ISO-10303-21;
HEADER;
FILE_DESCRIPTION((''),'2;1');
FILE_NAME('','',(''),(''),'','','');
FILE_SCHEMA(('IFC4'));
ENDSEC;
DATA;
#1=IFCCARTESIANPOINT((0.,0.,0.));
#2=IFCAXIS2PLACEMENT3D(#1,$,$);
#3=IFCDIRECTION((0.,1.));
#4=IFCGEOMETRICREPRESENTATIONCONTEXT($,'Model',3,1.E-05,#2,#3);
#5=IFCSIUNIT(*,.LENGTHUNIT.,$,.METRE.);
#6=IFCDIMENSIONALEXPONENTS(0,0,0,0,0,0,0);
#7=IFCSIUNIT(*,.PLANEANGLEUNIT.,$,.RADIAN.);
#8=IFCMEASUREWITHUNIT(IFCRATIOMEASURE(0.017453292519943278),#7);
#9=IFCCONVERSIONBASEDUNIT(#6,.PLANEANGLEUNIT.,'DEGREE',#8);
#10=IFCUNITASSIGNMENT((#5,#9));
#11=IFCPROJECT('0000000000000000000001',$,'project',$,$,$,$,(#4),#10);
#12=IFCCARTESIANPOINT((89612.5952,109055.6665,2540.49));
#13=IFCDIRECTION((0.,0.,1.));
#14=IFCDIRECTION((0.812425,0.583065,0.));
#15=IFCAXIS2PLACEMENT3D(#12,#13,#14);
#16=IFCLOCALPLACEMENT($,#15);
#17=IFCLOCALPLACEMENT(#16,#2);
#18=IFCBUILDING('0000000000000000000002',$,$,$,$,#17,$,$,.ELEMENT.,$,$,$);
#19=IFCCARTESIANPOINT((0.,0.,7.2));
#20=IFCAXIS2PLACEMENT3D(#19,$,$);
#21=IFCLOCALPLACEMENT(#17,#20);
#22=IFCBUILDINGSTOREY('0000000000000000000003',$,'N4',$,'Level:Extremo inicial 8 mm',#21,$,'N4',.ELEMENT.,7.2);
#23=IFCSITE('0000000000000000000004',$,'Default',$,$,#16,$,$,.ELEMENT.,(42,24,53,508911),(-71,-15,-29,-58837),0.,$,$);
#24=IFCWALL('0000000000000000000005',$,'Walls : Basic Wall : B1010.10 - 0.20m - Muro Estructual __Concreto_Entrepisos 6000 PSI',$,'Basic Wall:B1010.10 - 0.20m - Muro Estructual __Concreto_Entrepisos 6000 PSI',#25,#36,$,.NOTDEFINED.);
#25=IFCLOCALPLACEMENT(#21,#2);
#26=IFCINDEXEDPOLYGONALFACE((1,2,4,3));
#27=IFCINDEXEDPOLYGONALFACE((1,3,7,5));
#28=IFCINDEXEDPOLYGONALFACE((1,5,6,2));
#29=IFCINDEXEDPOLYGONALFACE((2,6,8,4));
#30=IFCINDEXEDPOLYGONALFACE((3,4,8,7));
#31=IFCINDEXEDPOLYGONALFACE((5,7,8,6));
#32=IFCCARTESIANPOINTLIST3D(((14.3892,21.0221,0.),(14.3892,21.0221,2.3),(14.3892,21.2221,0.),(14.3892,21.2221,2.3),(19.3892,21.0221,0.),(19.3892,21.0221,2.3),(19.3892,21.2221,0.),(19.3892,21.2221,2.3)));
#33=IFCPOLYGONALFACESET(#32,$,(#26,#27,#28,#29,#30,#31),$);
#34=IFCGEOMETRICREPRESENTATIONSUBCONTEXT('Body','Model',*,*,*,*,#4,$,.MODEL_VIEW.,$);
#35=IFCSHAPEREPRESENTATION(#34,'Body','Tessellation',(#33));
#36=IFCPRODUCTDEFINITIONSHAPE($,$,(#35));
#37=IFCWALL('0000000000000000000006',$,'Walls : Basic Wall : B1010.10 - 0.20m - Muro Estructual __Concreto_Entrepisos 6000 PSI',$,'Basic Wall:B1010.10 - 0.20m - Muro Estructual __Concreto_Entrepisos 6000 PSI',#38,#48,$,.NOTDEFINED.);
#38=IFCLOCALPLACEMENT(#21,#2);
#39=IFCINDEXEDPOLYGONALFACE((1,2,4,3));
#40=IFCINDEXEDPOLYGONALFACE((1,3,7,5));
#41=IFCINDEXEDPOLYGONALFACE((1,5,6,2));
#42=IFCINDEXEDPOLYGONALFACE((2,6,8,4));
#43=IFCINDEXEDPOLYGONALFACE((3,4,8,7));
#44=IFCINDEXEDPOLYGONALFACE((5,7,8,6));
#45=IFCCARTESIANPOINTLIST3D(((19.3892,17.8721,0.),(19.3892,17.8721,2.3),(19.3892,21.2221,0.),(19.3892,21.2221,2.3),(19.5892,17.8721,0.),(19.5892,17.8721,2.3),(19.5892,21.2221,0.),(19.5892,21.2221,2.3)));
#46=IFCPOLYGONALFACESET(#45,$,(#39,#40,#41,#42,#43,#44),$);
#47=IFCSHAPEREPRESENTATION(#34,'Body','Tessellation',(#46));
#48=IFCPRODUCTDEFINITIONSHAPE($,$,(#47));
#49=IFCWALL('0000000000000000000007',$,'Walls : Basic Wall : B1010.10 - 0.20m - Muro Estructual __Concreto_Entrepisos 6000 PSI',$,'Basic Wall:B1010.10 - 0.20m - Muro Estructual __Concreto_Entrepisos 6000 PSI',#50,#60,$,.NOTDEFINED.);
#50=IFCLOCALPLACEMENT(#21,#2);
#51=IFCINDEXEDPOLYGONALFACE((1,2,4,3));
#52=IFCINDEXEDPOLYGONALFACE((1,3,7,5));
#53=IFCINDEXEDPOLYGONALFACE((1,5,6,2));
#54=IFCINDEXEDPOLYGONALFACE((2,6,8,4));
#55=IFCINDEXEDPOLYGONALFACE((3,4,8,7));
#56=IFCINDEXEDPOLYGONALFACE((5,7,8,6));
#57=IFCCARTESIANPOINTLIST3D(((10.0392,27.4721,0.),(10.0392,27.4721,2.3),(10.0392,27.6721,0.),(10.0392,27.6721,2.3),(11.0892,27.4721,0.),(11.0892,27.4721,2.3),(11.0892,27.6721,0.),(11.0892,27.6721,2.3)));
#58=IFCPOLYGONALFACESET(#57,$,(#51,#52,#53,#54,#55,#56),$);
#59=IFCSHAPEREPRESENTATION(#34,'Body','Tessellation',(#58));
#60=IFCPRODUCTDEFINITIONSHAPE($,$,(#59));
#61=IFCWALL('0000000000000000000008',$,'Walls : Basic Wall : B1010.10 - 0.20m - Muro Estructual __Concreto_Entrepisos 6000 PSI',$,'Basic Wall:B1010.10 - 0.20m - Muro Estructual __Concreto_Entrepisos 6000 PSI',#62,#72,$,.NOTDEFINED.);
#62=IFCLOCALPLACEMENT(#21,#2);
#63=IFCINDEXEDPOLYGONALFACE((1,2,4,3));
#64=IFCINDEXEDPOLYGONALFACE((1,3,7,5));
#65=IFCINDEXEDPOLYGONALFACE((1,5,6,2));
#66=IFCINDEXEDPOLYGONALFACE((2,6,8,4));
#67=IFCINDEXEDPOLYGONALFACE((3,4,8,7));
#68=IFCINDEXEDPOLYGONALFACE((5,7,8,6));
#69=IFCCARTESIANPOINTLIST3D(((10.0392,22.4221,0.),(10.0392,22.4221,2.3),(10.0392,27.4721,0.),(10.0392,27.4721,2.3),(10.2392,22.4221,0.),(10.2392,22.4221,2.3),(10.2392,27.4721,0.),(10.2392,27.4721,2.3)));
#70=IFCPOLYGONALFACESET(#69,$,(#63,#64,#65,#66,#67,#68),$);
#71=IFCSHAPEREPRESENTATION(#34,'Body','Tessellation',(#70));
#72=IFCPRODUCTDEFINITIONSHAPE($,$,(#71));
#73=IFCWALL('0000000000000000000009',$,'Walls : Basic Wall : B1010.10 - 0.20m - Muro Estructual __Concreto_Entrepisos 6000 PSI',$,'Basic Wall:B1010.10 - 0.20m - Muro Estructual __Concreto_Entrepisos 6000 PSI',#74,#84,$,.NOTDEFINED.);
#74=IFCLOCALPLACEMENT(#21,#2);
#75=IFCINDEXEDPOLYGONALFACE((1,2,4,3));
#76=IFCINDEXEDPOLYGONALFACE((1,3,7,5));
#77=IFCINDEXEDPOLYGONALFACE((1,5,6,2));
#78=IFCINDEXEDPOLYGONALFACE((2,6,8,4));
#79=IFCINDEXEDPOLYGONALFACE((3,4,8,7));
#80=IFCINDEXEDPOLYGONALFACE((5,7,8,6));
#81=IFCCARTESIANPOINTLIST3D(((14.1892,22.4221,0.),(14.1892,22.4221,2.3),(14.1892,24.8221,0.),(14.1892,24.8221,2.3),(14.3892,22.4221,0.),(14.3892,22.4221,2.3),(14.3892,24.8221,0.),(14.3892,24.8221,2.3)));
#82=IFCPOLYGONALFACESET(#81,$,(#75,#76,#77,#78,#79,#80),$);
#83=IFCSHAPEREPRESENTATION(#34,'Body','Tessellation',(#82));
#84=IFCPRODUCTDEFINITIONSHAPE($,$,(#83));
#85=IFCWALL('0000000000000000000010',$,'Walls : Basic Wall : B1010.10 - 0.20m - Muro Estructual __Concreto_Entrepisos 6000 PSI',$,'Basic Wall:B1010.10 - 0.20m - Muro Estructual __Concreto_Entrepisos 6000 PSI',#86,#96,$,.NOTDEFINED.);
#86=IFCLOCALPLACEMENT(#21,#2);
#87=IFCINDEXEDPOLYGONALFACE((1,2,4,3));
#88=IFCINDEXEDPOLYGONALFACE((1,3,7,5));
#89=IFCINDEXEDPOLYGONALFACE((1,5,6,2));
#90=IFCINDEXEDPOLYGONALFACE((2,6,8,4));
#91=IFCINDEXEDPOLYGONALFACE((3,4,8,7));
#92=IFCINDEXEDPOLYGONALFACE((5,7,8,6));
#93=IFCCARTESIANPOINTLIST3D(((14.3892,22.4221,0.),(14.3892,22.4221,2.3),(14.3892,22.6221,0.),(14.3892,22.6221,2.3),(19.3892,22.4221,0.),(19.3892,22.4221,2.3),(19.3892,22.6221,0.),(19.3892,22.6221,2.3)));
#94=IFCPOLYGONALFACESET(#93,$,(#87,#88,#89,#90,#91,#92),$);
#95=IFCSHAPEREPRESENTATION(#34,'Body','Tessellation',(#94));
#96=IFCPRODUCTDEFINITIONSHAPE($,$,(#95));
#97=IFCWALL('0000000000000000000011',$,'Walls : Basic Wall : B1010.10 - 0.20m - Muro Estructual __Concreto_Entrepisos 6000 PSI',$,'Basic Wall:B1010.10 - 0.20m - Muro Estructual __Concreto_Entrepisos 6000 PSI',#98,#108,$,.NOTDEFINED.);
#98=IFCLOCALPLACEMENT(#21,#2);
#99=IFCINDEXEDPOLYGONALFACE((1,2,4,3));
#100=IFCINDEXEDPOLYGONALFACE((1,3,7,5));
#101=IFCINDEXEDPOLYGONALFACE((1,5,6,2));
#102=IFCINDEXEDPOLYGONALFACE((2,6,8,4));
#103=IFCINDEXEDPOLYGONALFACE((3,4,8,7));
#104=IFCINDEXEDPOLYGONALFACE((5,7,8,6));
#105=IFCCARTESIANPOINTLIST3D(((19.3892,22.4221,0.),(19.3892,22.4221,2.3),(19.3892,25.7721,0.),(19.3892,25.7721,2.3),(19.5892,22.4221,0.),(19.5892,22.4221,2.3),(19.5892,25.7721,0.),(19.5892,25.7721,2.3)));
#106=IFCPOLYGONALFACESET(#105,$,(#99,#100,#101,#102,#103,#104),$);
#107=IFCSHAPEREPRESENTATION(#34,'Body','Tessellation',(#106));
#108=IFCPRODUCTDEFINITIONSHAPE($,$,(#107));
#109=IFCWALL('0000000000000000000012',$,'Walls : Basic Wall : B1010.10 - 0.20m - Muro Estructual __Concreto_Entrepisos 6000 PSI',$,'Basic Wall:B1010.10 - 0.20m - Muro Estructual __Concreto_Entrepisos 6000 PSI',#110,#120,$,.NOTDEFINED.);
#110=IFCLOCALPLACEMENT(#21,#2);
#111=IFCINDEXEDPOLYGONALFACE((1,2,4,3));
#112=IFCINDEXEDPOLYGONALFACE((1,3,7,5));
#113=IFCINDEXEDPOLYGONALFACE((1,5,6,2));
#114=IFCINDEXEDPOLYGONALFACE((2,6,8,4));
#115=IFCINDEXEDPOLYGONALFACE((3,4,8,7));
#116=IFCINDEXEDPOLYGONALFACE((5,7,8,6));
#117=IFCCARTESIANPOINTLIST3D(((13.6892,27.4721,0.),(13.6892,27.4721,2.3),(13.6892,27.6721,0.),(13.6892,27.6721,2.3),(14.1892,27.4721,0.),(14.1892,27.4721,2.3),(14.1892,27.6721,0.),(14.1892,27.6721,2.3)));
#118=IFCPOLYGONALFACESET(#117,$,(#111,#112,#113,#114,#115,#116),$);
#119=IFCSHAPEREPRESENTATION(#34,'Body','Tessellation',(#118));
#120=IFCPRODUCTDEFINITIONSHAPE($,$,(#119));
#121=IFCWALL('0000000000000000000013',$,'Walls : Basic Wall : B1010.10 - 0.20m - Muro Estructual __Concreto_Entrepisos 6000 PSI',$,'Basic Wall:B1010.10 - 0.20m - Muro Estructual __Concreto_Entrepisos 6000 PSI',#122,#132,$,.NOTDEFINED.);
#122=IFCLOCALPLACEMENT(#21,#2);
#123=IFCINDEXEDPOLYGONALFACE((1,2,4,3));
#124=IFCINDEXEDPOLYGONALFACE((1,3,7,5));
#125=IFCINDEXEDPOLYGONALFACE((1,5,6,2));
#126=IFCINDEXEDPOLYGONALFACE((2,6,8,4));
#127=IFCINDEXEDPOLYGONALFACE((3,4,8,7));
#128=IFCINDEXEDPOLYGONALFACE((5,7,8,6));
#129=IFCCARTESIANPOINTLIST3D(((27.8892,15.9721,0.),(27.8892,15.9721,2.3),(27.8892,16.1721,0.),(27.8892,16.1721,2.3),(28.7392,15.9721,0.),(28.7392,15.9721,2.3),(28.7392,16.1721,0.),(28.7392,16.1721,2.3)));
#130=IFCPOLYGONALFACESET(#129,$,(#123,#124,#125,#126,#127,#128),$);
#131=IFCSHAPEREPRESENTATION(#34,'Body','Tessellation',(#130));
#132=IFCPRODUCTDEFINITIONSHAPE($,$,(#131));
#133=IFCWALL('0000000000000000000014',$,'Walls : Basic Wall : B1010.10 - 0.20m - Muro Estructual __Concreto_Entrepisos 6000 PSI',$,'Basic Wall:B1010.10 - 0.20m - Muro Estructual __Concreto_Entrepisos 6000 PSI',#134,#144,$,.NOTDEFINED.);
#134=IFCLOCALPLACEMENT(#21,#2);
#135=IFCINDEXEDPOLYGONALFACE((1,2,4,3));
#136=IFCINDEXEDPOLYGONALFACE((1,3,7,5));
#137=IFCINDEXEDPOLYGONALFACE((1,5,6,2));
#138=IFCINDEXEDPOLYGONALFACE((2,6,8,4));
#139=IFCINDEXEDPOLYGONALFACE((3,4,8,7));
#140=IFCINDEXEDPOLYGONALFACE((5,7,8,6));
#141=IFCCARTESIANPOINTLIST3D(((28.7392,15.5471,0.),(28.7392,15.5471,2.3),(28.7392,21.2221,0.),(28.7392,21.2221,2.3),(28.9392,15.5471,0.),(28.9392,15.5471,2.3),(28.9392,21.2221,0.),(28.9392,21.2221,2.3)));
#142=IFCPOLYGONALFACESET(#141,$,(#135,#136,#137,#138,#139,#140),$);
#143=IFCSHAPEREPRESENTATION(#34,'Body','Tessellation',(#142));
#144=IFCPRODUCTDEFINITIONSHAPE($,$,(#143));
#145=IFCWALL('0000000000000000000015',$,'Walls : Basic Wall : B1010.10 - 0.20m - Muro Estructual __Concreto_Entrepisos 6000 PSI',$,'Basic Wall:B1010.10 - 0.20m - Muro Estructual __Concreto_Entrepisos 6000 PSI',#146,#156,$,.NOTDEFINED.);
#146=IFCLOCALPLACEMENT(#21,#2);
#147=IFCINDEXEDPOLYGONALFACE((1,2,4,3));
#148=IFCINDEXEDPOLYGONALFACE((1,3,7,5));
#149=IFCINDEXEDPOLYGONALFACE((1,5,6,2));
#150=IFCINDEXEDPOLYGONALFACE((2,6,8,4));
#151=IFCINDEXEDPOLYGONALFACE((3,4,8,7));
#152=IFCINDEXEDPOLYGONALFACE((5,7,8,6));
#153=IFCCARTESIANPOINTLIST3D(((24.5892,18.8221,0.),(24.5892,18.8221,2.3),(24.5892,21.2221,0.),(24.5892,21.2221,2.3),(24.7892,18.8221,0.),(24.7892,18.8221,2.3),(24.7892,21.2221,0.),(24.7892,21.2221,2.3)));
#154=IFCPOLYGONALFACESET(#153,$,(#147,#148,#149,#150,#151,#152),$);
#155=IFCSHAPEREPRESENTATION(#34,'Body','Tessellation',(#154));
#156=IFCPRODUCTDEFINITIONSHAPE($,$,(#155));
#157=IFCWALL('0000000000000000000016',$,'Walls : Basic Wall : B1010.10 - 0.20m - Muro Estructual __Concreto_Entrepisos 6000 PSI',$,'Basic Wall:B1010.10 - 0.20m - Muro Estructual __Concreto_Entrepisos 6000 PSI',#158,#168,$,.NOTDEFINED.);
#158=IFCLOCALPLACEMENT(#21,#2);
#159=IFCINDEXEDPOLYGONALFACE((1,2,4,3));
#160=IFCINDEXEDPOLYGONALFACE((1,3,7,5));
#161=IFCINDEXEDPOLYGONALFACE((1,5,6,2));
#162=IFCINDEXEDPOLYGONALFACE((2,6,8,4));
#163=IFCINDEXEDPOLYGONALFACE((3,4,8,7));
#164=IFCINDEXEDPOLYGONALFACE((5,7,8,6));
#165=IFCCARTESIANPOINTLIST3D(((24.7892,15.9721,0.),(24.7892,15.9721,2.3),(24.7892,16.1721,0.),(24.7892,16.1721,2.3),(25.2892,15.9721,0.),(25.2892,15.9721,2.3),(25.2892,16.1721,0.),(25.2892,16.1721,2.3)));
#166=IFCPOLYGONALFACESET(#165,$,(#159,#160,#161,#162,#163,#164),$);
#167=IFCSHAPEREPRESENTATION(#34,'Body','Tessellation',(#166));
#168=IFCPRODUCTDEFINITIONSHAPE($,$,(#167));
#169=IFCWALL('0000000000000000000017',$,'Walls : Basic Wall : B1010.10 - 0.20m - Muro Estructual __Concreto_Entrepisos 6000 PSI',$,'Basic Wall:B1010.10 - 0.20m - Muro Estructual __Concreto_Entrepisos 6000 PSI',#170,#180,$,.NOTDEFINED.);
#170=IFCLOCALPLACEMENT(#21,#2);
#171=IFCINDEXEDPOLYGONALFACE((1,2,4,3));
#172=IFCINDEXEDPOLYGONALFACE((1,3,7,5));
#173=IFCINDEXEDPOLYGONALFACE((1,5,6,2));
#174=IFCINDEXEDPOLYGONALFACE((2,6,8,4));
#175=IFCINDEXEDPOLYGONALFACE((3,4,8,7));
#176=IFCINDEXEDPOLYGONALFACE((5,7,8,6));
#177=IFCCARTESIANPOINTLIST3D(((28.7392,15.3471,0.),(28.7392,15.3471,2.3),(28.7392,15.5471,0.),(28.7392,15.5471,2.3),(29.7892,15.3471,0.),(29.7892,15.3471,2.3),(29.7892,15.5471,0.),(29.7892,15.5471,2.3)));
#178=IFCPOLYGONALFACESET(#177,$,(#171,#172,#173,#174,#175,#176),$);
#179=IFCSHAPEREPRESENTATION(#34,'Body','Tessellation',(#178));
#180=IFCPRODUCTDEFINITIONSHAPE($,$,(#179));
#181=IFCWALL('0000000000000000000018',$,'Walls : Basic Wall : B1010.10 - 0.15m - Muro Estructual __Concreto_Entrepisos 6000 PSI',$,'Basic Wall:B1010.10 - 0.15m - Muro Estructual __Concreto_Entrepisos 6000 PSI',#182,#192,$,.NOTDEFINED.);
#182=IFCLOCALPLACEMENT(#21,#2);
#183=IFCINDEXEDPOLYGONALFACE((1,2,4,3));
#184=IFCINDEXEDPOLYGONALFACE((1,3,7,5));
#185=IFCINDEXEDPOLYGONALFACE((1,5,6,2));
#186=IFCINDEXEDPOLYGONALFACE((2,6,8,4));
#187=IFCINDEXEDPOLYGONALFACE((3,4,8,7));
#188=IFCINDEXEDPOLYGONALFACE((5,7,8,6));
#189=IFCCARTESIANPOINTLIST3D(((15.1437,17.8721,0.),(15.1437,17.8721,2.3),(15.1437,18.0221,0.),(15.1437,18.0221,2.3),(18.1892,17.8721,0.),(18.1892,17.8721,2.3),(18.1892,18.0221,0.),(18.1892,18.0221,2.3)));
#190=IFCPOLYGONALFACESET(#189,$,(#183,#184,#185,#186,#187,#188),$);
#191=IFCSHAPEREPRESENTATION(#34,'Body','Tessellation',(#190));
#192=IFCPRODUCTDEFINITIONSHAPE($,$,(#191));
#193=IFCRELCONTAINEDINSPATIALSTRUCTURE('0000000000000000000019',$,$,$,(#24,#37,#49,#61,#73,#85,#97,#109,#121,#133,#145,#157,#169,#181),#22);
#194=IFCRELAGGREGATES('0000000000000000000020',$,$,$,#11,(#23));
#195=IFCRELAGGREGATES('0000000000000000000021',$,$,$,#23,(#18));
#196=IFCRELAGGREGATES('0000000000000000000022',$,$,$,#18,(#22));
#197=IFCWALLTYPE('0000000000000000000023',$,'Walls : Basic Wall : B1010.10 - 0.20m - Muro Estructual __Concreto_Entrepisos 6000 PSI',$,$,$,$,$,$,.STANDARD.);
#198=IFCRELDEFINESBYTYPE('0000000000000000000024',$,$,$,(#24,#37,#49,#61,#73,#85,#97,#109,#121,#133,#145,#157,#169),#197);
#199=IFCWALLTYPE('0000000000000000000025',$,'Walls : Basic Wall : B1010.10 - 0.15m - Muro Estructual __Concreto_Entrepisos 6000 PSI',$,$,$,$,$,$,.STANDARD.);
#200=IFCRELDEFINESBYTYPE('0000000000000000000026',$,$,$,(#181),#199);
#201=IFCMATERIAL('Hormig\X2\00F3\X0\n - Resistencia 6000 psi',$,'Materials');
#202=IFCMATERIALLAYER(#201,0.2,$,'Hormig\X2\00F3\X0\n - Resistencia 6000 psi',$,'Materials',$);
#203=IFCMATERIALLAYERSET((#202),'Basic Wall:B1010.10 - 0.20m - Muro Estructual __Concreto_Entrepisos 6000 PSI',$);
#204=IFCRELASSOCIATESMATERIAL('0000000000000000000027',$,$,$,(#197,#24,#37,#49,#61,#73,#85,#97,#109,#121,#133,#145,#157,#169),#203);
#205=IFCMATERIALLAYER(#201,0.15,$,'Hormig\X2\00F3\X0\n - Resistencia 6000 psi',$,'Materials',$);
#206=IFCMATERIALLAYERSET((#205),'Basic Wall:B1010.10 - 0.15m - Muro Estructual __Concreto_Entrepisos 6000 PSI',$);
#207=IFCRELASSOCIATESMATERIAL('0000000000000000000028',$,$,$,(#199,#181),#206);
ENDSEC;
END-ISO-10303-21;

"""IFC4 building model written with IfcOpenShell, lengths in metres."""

from ifc_helpers import new_model, entity, si_unit, converted_unit, direction, frame, frame_2d, origin, place, context, subcontext, project, spatial, rectangle, extrude, material, layer, layer_set, layer_usage, type_object, element, save


model = new_model("IFC4")

# Units and contexts
model_context = context("Model", 3, precision=1e-05, world=origin(), true_north=direction((0.0, 1.0)))
body_context = subcontext(model_context, "Body", "Model", "MODEL_VIEW")
ifc_project = project(units=[si_unit("LENGTHUNIT", "METRE"), converted_unit("PLANEANGLEUNIT", "DEGREE", entity("IfcRatioMeasure", 0.017453292519943278), si_unit("PLANEANGLEUNIT", "RADIAN"), dimensions=[0, 0, 0, 0, 0, 0, 0])], contexts=[model_context])

# Site, building, storey
site_placement = place(None, frame((89612.5952, 109055.6665, 2540.49), z_axis=(0.0, 0.0, 1.0), x_axis=(0.812425, 0.583065, 0.0)))
site = spatial("IfcSite", under=ifc_project, at=site_placement, Name="Default", CompositionType="ELEMENT", RefLatitude=(42, 24, 53, 508911), RefLongitude=(-71, -15, -29, -58837), RefElevation=0.0)
building_placement = place(site_placement, origin())
building = spatial("IfcBuilding", under=site, at=building_placement, CompositionType="ELEMENT")
storey_placement = place(building_placement, frame((0.0, 0.0, 7.2)))
storey = spatial("IfcBuildingStorey", under=building, at=storey_placement, Name="N4", ObjectType="Level:Extremo inicial 8 mm", LongName="N4", CompositionType="ELEMENT", Elevation=7.2)

# Walls
ifc_material = material(Name="Hormigón - Resistencia 6000 psi", Category="Materials")
ifc_layer_1 = layer(ifc_material, 0.2, Name="Hormigón - Resistencia 6000 psi", Category="Materials")
ifc_layer_set_1 = layer_set([ifc_layer_1], Name="Basic Wall:B1010.10 - 0.20m - Muro Estructual __Concreto_Entrepisos 6000 PSI")
ifc_layer_usage_1 = layer_usage(ifc_layer_set_1, "AXIS2", "NEGATIVE", 0.1)
wall_type_1 = type_object("IfcWallType", Name="Walls : Basic Wall : B1010.10 - 0.20m - Muro Estructual __Concreto_Entrepisos 6000 PSI", PredefinedType="STANDARD", material=ifc_layer_set_1)
wall_1_placement = place(storey_placement, frame((14.3892, 21.1221, 0.0)))
element("IfcWall", 1, at=wall_1_placement, inside=storey, type_object=wall_type_1, material=ifc_layer_usage_1, Name="Walls : Basic Wall : B1010.10 - 0.20m - Muro Estructual __Concreto_Entrepisos 6000 PSI", ObjectType="Basic Wall:B1010.10 - 0.20m - Muro Estructual __Concreto_Entrepisos 6000 PSI", PredefinedType="NOTDEFINED", context=body_context, shape_type="SweptSolid", body=[
    extrude(rectangle(XDim=5.0, YDim=0.2, at=frame_2d((2.5, 0.0), x_axis=(-1.0, 0.0))), origin(), (0.0, 0.0, 1.0), 2.3),
])
ifc_layer_usage_2 = layer_usage(ifc_layer_set_1, "AXIS2", "NEGATIVE", 0.1)
wall_2_placement = place(storey_placement, frame((19.4892, 21.2221, 0.0), z_axis=(0.0, 0.0, 1.0), x_axis=(0.0, -1.0, 0.0)))
element("IfcWall", 2, at=wall_2_placement, inside=storey, type_object=wall_type_1, material=ifc_layer_usage_2, Name="Walls : Basic Wall : B1010.10 - 0.20m - Muro Estructual __Concreto_Entrepisos 6000 PSI", ObjectType="Basic Wall:B1010.10 - 0.20m - Muro Estructual __Concreto_Entrepisos 6000 PSI", PredefinedType="NOTDEFINED", context=body_context, shape_type="SweptSolid", body=[
    extrude(rectangle(XDim=3.35, YDim=0.2, at=frame_2d((1.675, 0.0), x_axis=(-1.0, 0.0))), origin(), (0.0, 0.0, 1.0), 2.3),
])
ifc_layer_usage_3 = layer_usage(ifc_layer_set_1, "AXIS2", "POSITIVE", -0.1)
wall_3_placement = place(storey_placement, frame((11.0892, 27.5721, 0.0), z_axis=(0.0, 0.0, 1.0), x_axis=(-1.0, 0.0, 0.0)))
element("IfcWall", 3, at=wall_3_placement, inside=storey, type_object=wall_type_1, material=ifc_layer_usage_3, Name="Walls : Basic Wall : B1010.10 - 0.20m - Muro Estructual __Concreto_Entrepisos 6000 PSI", ObjectType="Basic Wall:B1010.10 - 0.20m - Muro Estructual __Concreto_Entrepisos 6000 PSI", PredefinedType="NOTDEFINED", context=body_context, shape_type="SweptSolid", body=[
    extrude(rectangle(XDim=1.05, YDim=0.2, at=frame_2d((0.525, 0.0), x_axis=(-1.0, 0.0))), origin(), (0.0, 0.0, 1.0), 2.3),
])
ifc_layer_usage_4 = layer_usage(ifc_layer_set_1, "AXIS2", "POSITIVE", -0.1)
wall_4_placement = place(storey_placement, frame((10.1392, 27.4721, 0.0), z_axis=(0.0, 0.0, 1.0), x_axis=(0.0, -1.0, 0.0)))
element("IfcWall", 4, at=wall_4_placement, inside=storey, type_object=wall_type_1, material=ifc_layer_usage_4, Name="Walls : Basic Wall : B1010.10 - 0.20m - Muro Estructual __Concreto_Entrepisos 6000 PSI", ObjectType="Basic Wall:B1010.10 - 0.20m - Muro Estructual __Concreto_Entrepisos 6000 PSI", PredefinedType="NOTDEFINED", context=body_context, shape_type="SweptSolid", body=[
    extrude(rectangle(XDim=5.05, YDim=0.2, at=frame_2d((2.525, 0.0), x_axis=(-1.0, 0.0))), origin(), (0.0, 0.0, 1.0), 2.3),
])
ifc_layer_usage_5 = layer_usage(ifc_layer_set_1, "AXIS2", "POSITIVE", -0.1)
wall_5_placement = place(storey_placement, frame((14.2892, 24.8221, 0.0), z_axis=(0.0, 0.0, 1.0), x_axis=(0.0, -1.0, 0.0)))
element("IfcWall", 5, at=wall_5_placement, inside=storey, type_object=wall_type_1, material=ifc_layer_usage_5, Name="Walls : Basic Wall : B1010.10 - 0.20m - Muro Estructual __Concreto_Entrepisos 6000 PSI", ObjectType="Basic Wall:B1010.10 - 0.20m - Muro Estructual __Concreto_Entrepisos 6000 PSI", PredefinedType="NOTDEFINED", context=body_context, shape_type="SweptSolid", body=[
    extrude(rectangle(XDim=2.4, YDim=0.2, at=frame_2d((1.2, 0.0), x_axis=(-1.0, 0.0))), origin(), (0.0, 0.0, 1.0), 2.3),
])
ifc_layer_usage_6 = layer_usage(ifc_layer_set_1, "AXIS2", "POSITIVE", -0.1)
wall_6_placement = place(storey_placement, frame((14.3892, 22.5221, 0.0)))
element("IfcWall", 6, at=wall_6_placement, inside=storey, type_object=wall_type_1, material=ifc_layer_usage_6, Name="Walls : Basic Wall : B1010.10 - 0.20m - Muro Estructual __Concreto_Entrepisos 6000 PSI", ObjectType="Basic Wall:B1010.10 - 0.20m - Muro Estructual __Concreto_Entrepisos 6000 PSI", PredefinedType="NOTDEFINED", context=body_context, shape_type="SweptSolid", body=[
    extrude(rectangle(XDim=5.0, YDim=0.2, at=frame_2d((2.5, 0.0), x_axis=(-1.0, 0.0))), origin(), (0.0, 0.0, 1.0), 2.3),
])
ifc_layer_usage_7 = layer_usage(ifc_layer_set_1, "AXIS2", "POSITIVE", -0.1)
wall_7_placement = place(storey_placement, frame((19.4892, 22.4221, 0.0), z_axis=(0.0, 0.0, 1.0), x_axis=(0.0, 1.0, 0.0)))
element("IfcWall", 7, at=wall_7_placement, inside=storey, type_object=wall_type_1, material=ifc_layer_usage_7, Name="Walls : Basic Wall : B1010.10 - 0.20m - Muro Estructual __Concreto_Entrepisos 6000 PSI", ObjectType="Basic Wall:B1010.10 - 0.20m - Muro Estructual __Concreto_Entrepisos 6000 PSI", PredefinedType="NOTDEFINED", context=body_context, shape_type="SweptSolid", body=[
    extrude(rectangle(XDim=3.35, YDim=0.2, at=frame_2d((1.675, 0.0), x_axis=(-1.0, 0.0))), origin(), (0.0, 0.0, 1.0), 2.3),
])
ifc_layer_usage_8 = layer_usage(ifc_layer_set_1, "AXIS2", "POSITIVE", -0.1)
wall_8_placement = place(storey_placement, frame((13.6892, 27.5721, 0.0)))
element("IfcWall", 8, at=wall_8_placement, inside=storey, type_object=wall_type_1, material=ifc_layer_usage_8, Name="Walls : Basic Wall : B1010.10 - 0.20m - Muro Estructual __Concreto_Entrepisos 6000 PSI", ObjectType="Basic Wall:B1010.10 - 0.20m - Muro Estructual __Concreto_Entrepisos 6000 PSI", PredefinedType="NOTDEFINED", context=body_context, shape_type="SweptSolid", body=[
    extrude(rectangle(XDim=0.5, YDim=0.2, at=frame_2d((0.25, 0.0), x_axis=(-1.0, 0.0))), origin(), (0.0, 0.0, 1.0), 2.3),
])
ifc_layer_usage_9 = layer_usage(ifc_layer_set_1, "AXIS2", "POSITIVE", -0.1)
wall_9_placement = place(storey_placement, frame((27.8892, 16.0721, 0.0)))
element("IfcWall", 9, at=wall_9_placement, inside=storey, type_object=wall_type_1, material=ifc_layer_usage_9, Name="Walls : Basic Wall : B1010.10 - 0.20m - Muro Estructual __Concreto_Entrepisos 6000 PSI", ObjectType="Basic Wall:B1010.10 - 0.20m - Muro Estructual __Concreto_Entrepisos 6000 PSI", PredefinedType="NOTDEFINED", context=body_context, shape_type="SweptSolid", body=[
    extrude(rectangle(XDim=0.85, YDim=0.2, at=frame_2d((0.425, 0.0), x_axis=(-1.0, 0.0))), origin(), (0.0, 0.0, 1.0), 2.3),
])
ifc_layer_usage_10 = layer_usage(ifc_layer_set_1, "AXIS2", "POSITIVE", -0.1)
wall_10_placement = place(storey_placement, frame((28.8392, 15.5471, 0.0), z_axis=(0.0, 0.0, 1.0), x_axis=(0.0, 1.0, 0.0)))
element("IfcWall", 10, at=wall_10_placement, inside=storey, type_object=wall_type_1, material=ifc_layer_usage_10, Name="Walls : Basic Wall : B1010.10 - 0.20m - Muro Estructual __Concreto_Entrepisos 6000 PSI", ObjectType="Basic Wall:B1010.10 - 0.20m - Muro Estructual __Concreto_Entrepisos 6000 PSI", PredefinedType="NOTDEFINED", context=body_context, shape_type="SweptSolid", body=[
    extrude(rectangle(XDim=5.675, YDim=0.2, at=frame_2d((2.8375, 0.0), x_axis=(-1.0, 0.0))), origin(), (0.0, 0.0, 1.0), 2.3),
])
ifc_layer_usage_11 = layer_usage(ifc_layer_set_1, "AXIS2", "POSITIVE", -0.1)
wall_11_placement = place(storey_placement, frame((24.6892, 18.8221, 0.0), z_axis=(0.0, 0.0, 1.0), x_axis=(0.0, 1.0, 0.0)))
element("IfcWall", 11, at=wall_11_placement, inside=storey, type_object=wall_type_1, material=ifc_layer_usage_11, Name="Walls : Basic Wall : B1010.10 - 0.20m - Muro Estructual __Concreto_Entrepisos 6000 PSI", ObjectType="Basic Wall:B1010.10 - 0.20m - Muro Estructual __Concreto_Entrepisos 6000 PSI", PredefinedType="NOTDEFINED", context=body_context, shape_type="SweptSolid", body=[
    extrude(rectangle(XDim=2.4, YDim=0.2, at=frame_2d((1.2, 0.0), x_axis=(-1.0, 0.0))), origin(), (0.0, 0.0, 1.0), 2.3),
])
ifc_layer_usage_12 = layer_usage(ifc_layer_set_1, "AXIS2", "POSITIVE", -0.1)
wall_12_placement = place(storey_placement, frame((25.2892, 16.0721, 0.0), z_axis=(0.0, 0.0, 1.0), x_axis=(-1.0, 0.0, 0.0)))
element("IfcWall", 12, at=wall_12_placement, inside=storey, type_object=wall_type_1, material=ifc_layer_usage_12, Name="Walls : Basic Wall : B1010.10 - 0.20m - Muro Estructual __Concreto_Entrepisos 6000 PSI", ObjectType="Basic Wall:B1010.10 - 0.20m - Muro Estructual __Concreto_Entrepisos 6000 PSI", PredefinedType="NOTDEFINED", context=body_context, shape_type="SweptSolid", body=[
    extrude(rectangle(XDim=0.5, YDim=0.2, at=frame_2d((0.25, 0.0), x_axis=(-1.0, 0.0))), origin(), (0.0, 0.0, 1.0), 2.3),
])
ifc_layer_usage_13 = layer_usage(ifc_layer_set_1, "AXIS2", "NEGATIVE", 0.1)
wall_13_placement = place(storey_placement, frame((29.7892, 15.4471, 0.0), z_axis=(0.0, 0.0, 1.0), x_axis=(-1.0, 0.0, 0.0)))
element("IfcWall", 13, at=wall_13_placement, inside=storey, type_object=wall_type_1, material=ifc_layer_usage_13, Name="Walls : Basic Wall : B1010.10 - 0.20m - Muro Estructual __Concreto_Entrepisos 6000 PSI", ObjectType="Basic Wall:B1010.10 - 0.20m - Muro Estructual __Concreto_Entrepisos 6000 PSI", PredefinedType="NOTDEFINED", context=body_context, shape_type="SweptSolid", body=[
    extrude(rectangle(XDim=1.05, YDim=0.2, at=frame_2d((0.525, 0.0), x_axis=(-1.0, 0.0))), origin(), (0.0, 0.0, 1.0), 2.3),
])
ifc_layer_2 = layer(ifc_material, 0.15, Name="Hormigón - Resistencia 6000 psi", Category="Materials")
ifc_layer_set_2 = layer_set([ifc_layer_2], Name="Basic Wall:B1010.10 - 0.15m - Muro Estructual __Concreto_Entrepisos 6000 PSI")
ifc_layer_usage_14 = layer_usage(ifc_layer_set_2, "AXIS2", "NEGATIVE", 0.075)
wall_type_2 = type_object("IfcWallType", Name="Walls : Basic Wall : B1010.10 - 0.15m - Muro Estructual __Concreto_Entrepisos 6000 PSI", PredefinedType="STANDARD", material=ifc_layer_set_2)
wall_14_placement = place(storey_placement, frame((18.1892, 17.9471, 0.0), z_axis=(0.0, 0.0, 1.0), x_axis=(-1.0, 0.0, 0.0)))
element("IfcWall", 14, at=wall_14_placement, inside=storey, type_object=wall_type_2, material=ifc_layer_usage_14, Name="Walls : Basic Wall : B1010.10 - 0.15m - Muro Estructual __Concreto_Entrepisos 6000 PSI", ObjectType="Basic Wall:B1010.10 - 0.15m - Muro Estructual __Concreto_Entrepisos 6000 PSI", PredefinedType="NOTDEFINED", context=body_context, shape_type="SweptSolid", body=[
    extrude(rectangle(XDim=3.0455, YDim=0.15, at=frame_2d((1.5228, 0.0), x_axis=(-1.0, 0.0))), origin(), (0.0, 0.0, 1.0), 2.3),
])

save(model, "model.ifc")
